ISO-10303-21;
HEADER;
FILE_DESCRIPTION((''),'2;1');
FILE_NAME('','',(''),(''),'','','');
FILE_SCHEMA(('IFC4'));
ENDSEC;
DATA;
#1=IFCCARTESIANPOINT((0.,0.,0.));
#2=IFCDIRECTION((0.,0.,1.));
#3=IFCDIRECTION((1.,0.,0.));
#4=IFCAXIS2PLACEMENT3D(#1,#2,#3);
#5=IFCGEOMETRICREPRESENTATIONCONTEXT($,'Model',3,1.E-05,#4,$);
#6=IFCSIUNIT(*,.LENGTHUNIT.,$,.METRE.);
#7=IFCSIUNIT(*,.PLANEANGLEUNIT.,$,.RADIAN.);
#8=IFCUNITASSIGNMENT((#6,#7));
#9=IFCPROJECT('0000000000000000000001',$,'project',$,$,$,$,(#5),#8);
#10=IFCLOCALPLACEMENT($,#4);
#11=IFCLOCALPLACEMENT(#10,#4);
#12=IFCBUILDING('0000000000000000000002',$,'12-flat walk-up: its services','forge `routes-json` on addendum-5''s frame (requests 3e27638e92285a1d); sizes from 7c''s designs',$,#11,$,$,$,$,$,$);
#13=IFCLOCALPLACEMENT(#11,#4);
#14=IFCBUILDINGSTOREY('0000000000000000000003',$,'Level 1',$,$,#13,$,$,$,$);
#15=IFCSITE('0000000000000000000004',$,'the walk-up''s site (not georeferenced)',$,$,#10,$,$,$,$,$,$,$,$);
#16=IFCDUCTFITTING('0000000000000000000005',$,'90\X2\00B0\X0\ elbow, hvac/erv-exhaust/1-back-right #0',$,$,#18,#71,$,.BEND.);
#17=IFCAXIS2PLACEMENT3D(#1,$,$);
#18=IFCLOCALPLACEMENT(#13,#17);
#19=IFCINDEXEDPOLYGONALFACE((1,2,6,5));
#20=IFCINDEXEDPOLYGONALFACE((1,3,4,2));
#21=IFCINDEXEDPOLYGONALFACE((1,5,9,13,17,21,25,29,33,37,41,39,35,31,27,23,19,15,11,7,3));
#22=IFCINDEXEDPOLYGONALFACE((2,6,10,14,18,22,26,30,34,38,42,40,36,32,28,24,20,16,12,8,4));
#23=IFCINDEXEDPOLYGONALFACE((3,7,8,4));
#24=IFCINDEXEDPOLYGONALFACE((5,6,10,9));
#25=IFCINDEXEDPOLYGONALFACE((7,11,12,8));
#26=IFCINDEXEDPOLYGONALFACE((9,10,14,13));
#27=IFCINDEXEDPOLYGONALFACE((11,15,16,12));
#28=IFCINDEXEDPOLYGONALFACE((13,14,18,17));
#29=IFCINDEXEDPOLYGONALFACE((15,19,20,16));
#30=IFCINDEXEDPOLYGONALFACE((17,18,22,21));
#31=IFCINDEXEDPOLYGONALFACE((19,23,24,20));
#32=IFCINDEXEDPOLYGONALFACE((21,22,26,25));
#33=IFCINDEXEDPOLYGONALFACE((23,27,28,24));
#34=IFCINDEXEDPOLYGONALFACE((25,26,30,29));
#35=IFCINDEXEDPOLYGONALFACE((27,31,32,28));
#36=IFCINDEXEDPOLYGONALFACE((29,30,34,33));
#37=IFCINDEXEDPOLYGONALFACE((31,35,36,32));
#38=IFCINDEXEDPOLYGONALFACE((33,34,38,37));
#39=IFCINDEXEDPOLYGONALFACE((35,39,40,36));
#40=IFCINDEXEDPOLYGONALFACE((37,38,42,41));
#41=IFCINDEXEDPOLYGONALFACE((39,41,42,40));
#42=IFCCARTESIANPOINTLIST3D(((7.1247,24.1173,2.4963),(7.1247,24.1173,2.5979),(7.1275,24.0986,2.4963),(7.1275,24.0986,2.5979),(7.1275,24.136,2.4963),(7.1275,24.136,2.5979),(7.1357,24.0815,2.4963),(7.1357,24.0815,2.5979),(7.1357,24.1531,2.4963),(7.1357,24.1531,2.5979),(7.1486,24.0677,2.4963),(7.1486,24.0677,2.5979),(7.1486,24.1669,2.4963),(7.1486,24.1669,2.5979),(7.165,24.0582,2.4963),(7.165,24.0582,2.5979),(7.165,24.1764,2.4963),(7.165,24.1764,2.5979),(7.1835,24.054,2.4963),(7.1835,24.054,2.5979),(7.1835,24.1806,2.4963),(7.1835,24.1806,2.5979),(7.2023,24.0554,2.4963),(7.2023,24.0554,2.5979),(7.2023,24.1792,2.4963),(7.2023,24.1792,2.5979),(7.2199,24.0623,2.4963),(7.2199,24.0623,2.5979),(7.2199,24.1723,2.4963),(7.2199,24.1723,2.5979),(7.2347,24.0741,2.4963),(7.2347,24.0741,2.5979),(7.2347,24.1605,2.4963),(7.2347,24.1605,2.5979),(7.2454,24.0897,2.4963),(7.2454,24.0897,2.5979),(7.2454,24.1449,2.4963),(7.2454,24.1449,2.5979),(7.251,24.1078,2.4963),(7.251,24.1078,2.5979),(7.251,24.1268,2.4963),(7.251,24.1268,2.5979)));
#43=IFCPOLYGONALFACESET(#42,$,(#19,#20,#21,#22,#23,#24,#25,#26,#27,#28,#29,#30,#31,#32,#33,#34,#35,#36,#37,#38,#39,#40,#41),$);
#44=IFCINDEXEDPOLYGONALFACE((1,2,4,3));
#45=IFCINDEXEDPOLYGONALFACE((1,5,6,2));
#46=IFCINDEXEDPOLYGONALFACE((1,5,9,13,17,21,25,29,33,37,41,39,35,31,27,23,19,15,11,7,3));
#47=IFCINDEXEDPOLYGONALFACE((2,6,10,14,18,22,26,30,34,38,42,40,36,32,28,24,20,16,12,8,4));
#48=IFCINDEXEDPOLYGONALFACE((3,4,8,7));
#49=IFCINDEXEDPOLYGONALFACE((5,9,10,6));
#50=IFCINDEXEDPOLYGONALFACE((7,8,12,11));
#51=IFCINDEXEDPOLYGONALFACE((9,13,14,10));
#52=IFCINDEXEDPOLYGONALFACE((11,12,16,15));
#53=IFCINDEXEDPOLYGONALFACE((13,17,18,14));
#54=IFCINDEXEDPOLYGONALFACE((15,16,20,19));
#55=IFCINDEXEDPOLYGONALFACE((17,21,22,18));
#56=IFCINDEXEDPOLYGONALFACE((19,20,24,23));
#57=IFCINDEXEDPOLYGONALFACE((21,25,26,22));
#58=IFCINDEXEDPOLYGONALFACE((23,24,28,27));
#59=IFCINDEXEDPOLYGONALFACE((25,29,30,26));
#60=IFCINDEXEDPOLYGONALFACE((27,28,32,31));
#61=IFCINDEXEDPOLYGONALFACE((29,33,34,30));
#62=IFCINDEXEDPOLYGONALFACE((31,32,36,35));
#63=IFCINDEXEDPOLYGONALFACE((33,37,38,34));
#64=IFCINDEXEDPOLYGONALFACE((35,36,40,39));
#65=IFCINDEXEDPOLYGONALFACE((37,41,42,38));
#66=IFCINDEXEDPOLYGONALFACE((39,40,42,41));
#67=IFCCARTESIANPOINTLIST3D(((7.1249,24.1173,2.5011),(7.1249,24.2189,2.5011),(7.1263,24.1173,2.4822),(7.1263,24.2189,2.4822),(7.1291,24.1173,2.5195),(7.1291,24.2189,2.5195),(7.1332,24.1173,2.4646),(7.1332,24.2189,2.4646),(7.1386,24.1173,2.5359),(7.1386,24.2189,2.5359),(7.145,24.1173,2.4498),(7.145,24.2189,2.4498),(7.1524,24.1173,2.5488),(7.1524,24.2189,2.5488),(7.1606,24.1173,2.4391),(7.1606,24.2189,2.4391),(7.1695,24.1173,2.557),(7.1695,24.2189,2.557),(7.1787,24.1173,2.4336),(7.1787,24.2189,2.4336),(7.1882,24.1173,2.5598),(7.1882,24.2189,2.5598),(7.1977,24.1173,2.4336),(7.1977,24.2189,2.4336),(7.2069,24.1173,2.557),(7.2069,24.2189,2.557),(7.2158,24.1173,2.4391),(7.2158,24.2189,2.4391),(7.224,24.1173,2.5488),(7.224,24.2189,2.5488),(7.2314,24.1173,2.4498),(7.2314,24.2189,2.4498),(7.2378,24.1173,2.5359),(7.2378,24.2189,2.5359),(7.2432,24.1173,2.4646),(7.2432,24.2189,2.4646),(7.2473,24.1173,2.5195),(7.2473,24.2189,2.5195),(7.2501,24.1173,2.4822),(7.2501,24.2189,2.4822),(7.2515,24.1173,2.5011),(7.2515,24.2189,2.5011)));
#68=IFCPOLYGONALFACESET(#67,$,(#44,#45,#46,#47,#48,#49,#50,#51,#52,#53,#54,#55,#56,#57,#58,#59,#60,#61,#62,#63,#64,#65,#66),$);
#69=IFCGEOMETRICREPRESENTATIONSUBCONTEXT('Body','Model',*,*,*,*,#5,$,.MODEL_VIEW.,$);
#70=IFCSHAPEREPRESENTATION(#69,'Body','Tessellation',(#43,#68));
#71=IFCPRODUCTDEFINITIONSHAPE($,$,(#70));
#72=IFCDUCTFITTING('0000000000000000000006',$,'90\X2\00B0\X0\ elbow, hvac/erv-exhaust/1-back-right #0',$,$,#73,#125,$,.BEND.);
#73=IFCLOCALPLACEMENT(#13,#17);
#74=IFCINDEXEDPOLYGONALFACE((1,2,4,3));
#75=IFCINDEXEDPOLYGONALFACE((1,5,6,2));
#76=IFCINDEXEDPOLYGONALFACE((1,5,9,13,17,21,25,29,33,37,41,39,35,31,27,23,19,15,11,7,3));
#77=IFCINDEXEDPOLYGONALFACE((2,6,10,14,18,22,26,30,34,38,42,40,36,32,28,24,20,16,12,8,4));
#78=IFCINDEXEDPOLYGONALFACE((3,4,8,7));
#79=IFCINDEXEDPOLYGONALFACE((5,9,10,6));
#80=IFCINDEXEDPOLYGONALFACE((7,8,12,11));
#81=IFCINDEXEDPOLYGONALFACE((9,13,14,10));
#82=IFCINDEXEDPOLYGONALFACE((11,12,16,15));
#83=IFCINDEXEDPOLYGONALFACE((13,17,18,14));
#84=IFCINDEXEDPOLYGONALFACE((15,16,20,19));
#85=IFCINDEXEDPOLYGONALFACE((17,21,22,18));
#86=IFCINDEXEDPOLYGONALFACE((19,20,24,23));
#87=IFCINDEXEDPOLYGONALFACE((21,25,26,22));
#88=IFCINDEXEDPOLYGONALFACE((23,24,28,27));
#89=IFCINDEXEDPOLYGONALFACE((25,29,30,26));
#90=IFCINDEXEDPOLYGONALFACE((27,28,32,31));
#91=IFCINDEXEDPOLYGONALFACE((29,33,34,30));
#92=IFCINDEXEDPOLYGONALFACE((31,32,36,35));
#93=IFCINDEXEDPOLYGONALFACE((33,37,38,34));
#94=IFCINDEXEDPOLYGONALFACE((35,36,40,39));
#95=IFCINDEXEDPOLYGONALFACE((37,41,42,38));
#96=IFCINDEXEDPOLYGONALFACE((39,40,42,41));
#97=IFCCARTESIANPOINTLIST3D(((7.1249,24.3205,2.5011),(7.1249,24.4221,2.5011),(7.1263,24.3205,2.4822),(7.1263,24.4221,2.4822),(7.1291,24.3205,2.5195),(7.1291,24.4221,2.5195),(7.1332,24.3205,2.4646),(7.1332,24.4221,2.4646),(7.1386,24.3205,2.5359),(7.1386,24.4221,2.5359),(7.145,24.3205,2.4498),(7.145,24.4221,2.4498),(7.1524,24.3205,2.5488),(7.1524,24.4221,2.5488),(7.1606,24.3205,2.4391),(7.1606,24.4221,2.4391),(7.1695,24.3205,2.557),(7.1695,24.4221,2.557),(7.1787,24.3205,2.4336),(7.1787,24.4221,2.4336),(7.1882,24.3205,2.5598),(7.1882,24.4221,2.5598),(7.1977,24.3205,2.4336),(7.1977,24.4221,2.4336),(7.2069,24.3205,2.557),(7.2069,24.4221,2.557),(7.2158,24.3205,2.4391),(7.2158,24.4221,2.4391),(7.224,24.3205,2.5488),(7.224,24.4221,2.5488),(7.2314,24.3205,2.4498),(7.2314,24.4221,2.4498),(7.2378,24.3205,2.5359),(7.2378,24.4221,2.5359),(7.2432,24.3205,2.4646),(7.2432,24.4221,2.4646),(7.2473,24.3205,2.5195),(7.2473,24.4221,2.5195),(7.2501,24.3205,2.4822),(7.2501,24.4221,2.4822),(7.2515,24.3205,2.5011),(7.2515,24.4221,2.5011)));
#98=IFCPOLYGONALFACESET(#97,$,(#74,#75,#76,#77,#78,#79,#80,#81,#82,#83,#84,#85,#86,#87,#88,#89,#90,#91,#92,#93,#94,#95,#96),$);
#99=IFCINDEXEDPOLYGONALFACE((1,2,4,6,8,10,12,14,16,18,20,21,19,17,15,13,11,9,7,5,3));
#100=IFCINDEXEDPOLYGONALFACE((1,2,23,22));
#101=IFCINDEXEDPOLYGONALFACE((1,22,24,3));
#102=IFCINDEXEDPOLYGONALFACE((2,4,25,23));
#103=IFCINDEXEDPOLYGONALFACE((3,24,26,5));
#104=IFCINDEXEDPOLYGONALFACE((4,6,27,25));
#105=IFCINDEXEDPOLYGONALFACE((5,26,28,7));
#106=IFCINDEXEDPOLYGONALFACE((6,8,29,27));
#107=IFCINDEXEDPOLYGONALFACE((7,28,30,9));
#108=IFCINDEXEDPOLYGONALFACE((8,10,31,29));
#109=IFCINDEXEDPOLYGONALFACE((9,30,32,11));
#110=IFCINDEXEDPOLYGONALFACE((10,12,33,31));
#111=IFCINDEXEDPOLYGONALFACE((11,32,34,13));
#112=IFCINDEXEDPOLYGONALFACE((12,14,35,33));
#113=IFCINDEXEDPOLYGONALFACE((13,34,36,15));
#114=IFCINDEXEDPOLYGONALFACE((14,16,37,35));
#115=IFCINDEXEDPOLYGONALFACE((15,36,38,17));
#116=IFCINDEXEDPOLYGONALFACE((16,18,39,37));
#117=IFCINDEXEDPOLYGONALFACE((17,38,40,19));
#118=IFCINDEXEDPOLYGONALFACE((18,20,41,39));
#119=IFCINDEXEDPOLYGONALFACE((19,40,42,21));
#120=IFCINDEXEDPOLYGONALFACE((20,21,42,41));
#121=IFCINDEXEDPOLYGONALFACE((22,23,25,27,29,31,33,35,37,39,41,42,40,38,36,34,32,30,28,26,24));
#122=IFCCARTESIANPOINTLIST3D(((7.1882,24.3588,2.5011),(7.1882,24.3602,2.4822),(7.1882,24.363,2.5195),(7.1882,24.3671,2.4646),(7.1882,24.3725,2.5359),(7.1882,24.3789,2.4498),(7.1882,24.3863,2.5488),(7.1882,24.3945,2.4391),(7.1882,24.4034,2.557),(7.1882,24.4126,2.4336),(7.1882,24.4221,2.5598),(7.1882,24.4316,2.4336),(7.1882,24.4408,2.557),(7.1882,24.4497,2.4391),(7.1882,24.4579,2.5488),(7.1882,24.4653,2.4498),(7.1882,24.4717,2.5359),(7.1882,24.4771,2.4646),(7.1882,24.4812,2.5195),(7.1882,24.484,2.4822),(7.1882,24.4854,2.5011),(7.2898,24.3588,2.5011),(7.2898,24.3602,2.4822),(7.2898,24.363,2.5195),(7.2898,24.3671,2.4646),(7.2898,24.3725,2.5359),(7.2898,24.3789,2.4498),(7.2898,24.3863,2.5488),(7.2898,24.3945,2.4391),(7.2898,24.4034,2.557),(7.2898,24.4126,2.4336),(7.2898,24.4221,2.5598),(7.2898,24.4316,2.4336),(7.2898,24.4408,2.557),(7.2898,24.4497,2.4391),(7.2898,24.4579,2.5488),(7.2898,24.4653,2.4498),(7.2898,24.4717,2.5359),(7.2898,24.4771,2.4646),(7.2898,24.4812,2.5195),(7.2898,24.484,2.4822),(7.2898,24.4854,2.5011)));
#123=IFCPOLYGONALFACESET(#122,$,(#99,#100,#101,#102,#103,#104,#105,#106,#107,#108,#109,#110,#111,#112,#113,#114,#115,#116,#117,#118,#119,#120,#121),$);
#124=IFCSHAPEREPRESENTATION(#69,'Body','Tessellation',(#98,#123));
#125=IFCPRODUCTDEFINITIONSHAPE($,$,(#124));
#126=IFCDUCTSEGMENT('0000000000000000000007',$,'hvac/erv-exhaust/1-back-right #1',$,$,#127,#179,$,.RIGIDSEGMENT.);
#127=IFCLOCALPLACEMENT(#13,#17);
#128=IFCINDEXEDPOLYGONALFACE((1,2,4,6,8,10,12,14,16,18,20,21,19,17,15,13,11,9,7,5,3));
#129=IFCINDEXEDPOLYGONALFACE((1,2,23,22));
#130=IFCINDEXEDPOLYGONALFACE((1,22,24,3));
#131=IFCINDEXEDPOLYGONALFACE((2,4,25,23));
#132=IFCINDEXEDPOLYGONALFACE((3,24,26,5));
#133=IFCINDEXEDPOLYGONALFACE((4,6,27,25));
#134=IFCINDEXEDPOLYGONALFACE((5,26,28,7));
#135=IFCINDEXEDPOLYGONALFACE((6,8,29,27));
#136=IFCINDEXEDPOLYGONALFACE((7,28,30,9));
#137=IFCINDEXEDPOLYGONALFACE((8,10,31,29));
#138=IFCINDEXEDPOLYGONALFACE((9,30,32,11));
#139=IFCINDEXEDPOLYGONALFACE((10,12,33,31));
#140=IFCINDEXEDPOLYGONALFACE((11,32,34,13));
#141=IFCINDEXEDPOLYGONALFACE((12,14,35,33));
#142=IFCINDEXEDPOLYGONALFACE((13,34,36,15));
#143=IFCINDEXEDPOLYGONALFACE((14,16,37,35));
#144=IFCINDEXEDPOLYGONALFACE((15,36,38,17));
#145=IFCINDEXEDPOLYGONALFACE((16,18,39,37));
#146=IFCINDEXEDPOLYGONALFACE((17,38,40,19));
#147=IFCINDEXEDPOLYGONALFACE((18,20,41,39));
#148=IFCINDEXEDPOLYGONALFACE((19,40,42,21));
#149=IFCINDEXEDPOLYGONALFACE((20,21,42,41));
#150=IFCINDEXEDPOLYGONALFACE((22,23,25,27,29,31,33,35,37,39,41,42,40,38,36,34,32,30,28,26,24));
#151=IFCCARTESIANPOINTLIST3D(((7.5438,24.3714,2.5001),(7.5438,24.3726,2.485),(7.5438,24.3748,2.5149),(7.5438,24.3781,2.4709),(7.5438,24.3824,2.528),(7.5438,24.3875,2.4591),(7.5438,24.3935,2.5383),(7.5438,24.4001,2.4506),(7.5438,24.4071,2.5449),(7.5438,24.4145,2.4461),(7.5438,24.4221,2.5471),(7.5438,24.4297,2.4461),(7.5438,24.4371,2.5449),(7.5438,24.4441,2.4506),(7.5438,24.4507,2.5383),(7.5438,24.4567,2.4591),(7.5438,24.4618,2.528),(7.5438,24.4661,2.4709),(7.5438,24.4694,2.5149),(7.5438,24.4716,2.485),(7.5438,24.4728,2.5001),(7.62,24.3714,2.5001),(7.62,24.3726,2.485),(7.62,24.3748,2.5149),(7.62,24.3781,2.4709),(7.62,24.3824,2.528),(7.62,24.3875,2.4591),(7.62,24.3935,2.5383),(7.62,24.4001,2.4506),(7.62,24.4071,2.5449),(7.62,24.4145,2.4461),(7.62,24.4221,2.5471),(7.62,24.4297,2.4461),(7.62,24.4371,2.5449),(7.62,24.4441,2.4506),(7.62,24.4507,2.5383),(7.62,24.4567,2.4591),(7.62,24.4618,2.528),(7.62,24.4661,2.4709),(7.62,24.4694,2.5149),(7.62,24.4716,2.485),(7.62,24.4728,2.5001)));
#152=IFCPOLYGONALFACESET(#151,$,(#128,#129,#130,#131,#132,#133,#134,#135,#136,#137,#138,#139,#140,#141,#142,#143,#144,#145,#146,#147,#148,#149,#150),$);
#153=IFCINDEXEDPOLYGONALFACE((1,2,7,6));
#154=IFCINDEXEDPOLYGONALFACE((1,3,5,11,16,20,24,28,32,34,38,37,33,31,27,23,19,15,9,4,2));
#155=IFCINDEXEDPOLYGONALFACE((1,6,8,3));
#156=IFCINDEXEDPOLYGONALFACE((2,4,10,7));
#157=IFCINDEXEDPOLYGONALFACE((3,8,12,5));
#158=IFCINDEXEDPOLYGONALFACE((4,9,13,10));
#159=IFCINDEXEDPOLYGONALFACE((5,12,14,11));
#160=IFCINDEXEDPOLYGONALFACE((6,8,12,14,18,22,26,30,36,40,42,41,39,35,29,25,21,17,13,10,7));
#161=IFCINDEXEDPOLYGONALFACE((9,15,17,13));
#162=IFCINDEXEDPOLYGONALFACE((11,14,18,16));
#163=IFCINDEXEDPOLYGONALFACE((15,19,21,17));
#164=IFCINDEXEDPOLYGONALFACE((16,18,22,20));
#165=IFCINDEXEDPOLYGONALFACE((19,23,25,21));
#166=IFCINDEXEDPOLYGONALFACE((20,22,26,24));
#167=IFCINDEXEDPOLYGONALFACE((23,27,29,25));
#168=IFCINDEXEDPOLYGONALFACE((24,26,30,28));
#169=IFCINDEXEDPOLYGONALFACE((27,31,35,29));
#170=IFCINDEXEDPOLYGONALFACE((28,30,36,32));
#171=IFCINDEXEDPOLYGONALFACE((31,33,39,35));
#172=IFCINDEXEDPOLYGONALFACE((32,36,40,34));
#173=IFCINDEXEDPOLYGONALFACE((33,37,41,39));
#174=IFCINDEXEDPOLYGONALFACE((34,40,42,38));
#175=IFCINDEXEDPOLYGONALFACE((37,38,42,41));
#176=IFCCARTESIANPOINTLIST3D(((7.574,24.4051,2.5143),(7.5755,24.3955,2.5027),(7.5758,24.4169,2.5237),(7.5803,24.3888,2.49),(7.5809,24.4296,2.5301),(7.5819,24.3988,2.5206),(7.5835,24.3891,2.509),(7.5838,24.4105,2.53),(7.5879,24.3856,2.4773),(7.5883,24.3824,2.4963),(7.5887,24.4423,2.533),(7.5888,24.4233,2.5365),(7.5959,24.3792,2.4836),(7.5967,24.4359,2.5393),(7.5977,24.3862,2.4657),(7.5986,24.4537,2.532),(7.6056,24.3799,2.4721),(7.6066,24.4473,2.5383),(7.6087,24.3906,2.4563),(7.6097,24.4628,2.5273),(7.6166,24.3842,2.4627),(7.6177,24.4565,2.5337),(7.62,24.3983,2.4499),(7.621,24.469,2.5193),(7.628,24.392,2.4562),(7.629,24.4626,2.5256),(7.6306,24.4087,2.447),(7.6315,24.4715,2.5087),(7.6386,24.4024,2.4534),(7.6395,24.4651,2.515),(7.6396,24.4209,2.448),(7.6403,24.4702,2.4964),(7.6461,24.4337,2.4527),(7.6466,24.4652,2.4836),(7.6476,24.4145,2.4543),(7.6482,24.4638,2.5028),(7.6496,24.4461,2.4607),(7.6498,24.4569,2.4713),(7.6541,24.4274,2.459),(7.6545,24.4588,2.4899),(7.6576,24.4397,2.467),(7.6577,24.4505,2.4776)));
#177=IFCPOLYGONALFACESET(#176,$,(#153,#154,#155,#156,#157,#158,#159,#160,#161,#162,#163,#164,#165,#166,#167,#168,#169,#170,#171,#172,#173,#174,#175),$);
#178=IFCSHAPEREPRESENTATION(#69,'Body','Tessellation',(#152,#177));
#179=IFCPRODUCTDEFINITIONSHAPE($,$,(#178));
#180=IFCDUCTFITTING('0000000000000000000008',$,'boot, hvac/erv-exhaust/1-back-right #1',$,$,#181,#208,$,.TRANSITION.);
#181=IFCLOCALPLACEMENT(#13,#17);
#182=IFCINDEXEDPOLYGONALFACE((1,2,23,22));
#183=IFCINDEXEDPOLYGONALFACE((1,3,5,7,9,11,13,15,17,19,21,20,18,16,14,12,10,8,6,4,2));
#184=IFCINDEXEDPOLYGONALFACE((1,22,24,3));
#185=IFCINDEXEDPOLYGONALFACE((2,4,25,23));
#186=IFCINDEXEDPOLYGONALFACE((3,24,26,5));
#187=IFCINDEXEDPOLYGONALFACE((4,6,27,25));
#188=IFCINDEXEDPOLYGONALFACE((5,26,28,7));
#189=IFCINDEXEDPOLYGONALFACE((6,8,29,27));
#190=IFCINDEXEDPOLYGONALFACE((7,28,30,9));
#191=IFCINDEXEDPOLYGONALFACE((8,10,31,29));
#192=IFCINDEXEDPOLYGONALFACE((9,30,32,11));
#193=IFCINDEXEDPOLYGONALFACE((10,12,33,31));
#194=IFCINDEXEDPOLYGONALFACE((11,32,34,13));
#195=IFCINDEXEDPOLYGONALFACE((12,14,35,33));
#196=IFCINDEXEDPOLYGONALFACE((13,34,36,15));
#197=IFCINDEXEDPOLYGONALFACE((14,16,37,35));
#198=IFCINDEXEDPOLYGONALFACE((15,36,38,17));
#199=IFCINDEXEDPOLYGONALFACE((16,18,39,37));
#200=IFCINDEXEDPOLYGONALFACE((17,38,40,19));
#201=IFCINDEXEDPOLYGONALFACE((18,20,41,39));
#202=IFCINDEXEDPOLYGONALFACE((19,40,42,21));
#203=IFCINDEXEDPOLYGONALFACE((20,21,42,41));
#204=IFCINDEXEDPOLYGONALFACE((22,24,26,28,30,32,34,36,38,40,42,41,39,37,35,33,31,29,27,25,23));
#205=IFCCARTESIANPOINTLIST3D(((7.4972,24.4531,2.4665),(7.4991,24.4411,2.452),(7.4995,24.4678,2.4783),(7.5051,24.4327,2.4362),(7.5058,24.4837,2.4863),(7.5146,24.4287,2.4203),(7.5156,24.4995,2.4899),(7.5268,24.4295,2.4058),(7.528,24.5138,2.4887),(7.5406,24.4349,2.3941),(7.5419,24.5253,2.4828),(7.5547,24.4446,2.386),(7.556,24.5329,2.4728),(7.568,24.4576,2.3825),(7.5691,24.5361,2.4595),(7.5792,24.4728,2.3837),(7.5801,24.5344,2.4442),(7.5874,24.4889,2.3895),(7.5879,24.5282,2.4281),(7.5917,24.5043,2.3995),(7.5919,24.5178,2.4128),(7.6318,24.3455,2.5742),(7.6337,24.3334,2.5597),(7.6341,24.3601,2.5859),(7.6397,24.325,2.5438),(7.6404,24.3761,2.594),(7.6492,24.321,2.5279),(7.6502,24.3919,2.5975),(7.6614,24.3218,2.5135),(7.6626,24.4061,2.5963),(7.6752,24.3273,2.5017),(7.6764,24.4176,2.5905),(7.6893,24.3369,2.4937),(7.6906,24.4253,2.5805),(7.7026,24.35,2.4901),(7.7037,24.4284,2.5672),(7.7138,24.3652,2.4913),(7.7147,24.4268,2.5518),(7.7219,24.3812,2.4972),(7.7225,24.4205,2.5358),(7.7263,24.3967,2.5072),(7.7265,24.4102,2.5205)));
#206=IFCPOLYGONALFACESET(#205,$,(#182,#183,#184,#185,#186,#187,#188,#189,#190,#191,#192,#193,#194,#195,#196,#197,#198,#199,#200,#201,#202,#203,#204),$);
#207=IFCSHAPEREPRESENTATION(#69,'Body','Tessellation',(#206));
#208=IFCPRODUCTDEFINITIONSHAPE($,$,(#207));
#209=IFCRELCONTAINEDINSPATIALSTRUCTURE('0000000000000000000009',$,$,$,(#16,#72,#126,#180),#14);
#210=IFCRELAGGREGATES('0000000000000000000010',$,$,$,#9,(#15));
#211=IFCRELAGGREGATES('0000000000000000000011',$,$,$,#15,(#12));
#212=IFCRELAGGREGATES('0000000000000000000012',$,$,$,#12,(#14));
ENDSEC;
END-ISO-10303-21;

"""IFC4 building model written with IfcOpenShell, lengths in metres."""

from ifc_helpers import new_model, entity, si_unit, frame, origin_with_axes, place, context, subcontext, project, spatial, element, save


model = new_model("IFC4")

# Units and contexts
model_context = context("Model", 3, precision=1e-05, world=origin_with_axes())
body_context = subcontext(model_context, "Body", "Model", "MODEL_VIEW")
ifc_project = project(units=[si_unit("LENGTHUNIT", "METRE"), si_unit("PLANEANGLEUNIT", "RADIAN")], contexts=[model_context])

# Site, building, storey
site_placement = place(None, origin_with_axes())
site = spatial("IfcSite", under=ifc_project, at=site_placement, Name="the walk-up's site (not georeferenced)")
building_placement = place(site_placement, origin_with_axes())
building = spatial("IfcBuilding", under=site, at=building_placement, Name="12-flat walk-up: its services", Description="forge `routes-json` on addendum-5's frame (requests 3e27638e92285a1d); sizes from 7c's designs")
storey_placement = place(building_placement, origin_with_axes())
storey = spatial("IfcBuildingStorey", under=building, at=storey_placement, Name="Level 1")

# Duct fittings
duct_fitting_1_placement = place(storey_placement, frame((7.1882, 24.1173, 2.5979), z_axis=(0.0, 0.0, 1.0), x_axis=(1.0, 0.0, 0.0)))
element("IfcDuctFitting", 1, at=duct_fitting_1_placement, inside=storey, Name="90° elbow, hvac/erv-exhaust/1-back-right #0", PredefinedType="BEND", context=body_context, shape_type="AdvancedSweptSolid", body=[
    entity("IfcSweptDiskSolid", entity("IfcPolyline", [entity("IfcCartesianPoint", [0.0, 0.0, 0.0]), entity("IfcCartesianPoint", [0.0, 0.0, -0.1016])]), 0.0635),
    entity("IfcSweptDiskSolid", entity("IfcPolyline", [entity("IfcCartesianPoint", [0.0, 0.0, -0.1016]), entity("IfcCartesianPoint", [0.0, 0.1016, -0.1016])]), 0.0635),
])
duct_fitting_2_placement = place(storey_placement, frame((7.1882, 24.3205, 2.4963), z_axis=(0.0, 0.0, 1.0), x_axis=(1.0, 0.0, 0.0)))
element("IfcDuctFitting", 2, at=duct_fitting_2_placement, inside=storey, Name="90° elbow, hvac/erv-exhaust/1-back-right #0", PredefinedType="BEND", context=body_context, shape_type="AdvancedSweptSolid", body=[
    entity("IfcSweptDiskSolid", entity("IfcPolyline", [entity("IfcCartesianPoint", [0.0, 0.0, 0.0]), entity("IfcCartesianPoint", [0.0, 0.1016, 0.0])]), 0.0635),
    entity("IfcSweptDiskSolid", entity("IfcPolyline", [entity("IfcCartesianPoint", [0.0, 0.1016, 0.0]), entity("IfcCartesianPoint", [0.1016, 0.1016, 0.0])]), 0.0635),
])

# Duct segment
duct_segment_1_placement = place(storey_placement, frame((7.5438, 24.4221, 2.4963), z_axis=(0.0, 0.0, 1.0), x_axis=(1.0, 0.0, 0.0)))
element("IfcDuctSegment", 3, at=duct_segment_1_placement, inside=storey, Name="hvac/erv-exhaust/1-back-right #1", PredefinedType="RIGIDSEGMENT", context=body_context, shape_type="AdvancedSweptSolid", body=[
    entity("IfcSweptDiskSolid", entity("IfcPolyline", [entity("IfcCartesianPoint", [0.0, 0.0, 0.0]), entity("IfcCartesianPoint", [0.0762, 0.0, 0.0])]), 0.0508),
    entity("IfcSweptDiskSolid", entity("IfcPolyline", [entity("IfcCartesianPoint", [0.0762, 0.0, 0.0]), entity("IfcCartesianPoint", [0.0683, 0.0064, -0.0063])]), 0.0508),
])

# Duct fitting
duct_fitting_3_placement = place(storey_placement, frame((7.6794, 24.3746, 2.5438), z_axis=(0.0, 0.0, 1.0), x_axis=(1.0, 0.0, 0.0)))
element("IfcDuctFitting", 4, at=duct_fitting_3_placement, inside=storey, Name="boot, hvac/erv-exhaust/1-back-right #1", PredefinedType="TRANSITION", context=body_context, shape_type="AdvancedSweptSolid", body=[
    entity("IfcSweptDiskSolid", entity("IfcPolyline", [entity("IfcCartesianPoint", [0.0, 0.0, 0.0]), entity("IfcCartesianPoint", [-0.1346, 0.1077, -0.1077])]), 0.0635),
])

save(model, "model.ifc")
